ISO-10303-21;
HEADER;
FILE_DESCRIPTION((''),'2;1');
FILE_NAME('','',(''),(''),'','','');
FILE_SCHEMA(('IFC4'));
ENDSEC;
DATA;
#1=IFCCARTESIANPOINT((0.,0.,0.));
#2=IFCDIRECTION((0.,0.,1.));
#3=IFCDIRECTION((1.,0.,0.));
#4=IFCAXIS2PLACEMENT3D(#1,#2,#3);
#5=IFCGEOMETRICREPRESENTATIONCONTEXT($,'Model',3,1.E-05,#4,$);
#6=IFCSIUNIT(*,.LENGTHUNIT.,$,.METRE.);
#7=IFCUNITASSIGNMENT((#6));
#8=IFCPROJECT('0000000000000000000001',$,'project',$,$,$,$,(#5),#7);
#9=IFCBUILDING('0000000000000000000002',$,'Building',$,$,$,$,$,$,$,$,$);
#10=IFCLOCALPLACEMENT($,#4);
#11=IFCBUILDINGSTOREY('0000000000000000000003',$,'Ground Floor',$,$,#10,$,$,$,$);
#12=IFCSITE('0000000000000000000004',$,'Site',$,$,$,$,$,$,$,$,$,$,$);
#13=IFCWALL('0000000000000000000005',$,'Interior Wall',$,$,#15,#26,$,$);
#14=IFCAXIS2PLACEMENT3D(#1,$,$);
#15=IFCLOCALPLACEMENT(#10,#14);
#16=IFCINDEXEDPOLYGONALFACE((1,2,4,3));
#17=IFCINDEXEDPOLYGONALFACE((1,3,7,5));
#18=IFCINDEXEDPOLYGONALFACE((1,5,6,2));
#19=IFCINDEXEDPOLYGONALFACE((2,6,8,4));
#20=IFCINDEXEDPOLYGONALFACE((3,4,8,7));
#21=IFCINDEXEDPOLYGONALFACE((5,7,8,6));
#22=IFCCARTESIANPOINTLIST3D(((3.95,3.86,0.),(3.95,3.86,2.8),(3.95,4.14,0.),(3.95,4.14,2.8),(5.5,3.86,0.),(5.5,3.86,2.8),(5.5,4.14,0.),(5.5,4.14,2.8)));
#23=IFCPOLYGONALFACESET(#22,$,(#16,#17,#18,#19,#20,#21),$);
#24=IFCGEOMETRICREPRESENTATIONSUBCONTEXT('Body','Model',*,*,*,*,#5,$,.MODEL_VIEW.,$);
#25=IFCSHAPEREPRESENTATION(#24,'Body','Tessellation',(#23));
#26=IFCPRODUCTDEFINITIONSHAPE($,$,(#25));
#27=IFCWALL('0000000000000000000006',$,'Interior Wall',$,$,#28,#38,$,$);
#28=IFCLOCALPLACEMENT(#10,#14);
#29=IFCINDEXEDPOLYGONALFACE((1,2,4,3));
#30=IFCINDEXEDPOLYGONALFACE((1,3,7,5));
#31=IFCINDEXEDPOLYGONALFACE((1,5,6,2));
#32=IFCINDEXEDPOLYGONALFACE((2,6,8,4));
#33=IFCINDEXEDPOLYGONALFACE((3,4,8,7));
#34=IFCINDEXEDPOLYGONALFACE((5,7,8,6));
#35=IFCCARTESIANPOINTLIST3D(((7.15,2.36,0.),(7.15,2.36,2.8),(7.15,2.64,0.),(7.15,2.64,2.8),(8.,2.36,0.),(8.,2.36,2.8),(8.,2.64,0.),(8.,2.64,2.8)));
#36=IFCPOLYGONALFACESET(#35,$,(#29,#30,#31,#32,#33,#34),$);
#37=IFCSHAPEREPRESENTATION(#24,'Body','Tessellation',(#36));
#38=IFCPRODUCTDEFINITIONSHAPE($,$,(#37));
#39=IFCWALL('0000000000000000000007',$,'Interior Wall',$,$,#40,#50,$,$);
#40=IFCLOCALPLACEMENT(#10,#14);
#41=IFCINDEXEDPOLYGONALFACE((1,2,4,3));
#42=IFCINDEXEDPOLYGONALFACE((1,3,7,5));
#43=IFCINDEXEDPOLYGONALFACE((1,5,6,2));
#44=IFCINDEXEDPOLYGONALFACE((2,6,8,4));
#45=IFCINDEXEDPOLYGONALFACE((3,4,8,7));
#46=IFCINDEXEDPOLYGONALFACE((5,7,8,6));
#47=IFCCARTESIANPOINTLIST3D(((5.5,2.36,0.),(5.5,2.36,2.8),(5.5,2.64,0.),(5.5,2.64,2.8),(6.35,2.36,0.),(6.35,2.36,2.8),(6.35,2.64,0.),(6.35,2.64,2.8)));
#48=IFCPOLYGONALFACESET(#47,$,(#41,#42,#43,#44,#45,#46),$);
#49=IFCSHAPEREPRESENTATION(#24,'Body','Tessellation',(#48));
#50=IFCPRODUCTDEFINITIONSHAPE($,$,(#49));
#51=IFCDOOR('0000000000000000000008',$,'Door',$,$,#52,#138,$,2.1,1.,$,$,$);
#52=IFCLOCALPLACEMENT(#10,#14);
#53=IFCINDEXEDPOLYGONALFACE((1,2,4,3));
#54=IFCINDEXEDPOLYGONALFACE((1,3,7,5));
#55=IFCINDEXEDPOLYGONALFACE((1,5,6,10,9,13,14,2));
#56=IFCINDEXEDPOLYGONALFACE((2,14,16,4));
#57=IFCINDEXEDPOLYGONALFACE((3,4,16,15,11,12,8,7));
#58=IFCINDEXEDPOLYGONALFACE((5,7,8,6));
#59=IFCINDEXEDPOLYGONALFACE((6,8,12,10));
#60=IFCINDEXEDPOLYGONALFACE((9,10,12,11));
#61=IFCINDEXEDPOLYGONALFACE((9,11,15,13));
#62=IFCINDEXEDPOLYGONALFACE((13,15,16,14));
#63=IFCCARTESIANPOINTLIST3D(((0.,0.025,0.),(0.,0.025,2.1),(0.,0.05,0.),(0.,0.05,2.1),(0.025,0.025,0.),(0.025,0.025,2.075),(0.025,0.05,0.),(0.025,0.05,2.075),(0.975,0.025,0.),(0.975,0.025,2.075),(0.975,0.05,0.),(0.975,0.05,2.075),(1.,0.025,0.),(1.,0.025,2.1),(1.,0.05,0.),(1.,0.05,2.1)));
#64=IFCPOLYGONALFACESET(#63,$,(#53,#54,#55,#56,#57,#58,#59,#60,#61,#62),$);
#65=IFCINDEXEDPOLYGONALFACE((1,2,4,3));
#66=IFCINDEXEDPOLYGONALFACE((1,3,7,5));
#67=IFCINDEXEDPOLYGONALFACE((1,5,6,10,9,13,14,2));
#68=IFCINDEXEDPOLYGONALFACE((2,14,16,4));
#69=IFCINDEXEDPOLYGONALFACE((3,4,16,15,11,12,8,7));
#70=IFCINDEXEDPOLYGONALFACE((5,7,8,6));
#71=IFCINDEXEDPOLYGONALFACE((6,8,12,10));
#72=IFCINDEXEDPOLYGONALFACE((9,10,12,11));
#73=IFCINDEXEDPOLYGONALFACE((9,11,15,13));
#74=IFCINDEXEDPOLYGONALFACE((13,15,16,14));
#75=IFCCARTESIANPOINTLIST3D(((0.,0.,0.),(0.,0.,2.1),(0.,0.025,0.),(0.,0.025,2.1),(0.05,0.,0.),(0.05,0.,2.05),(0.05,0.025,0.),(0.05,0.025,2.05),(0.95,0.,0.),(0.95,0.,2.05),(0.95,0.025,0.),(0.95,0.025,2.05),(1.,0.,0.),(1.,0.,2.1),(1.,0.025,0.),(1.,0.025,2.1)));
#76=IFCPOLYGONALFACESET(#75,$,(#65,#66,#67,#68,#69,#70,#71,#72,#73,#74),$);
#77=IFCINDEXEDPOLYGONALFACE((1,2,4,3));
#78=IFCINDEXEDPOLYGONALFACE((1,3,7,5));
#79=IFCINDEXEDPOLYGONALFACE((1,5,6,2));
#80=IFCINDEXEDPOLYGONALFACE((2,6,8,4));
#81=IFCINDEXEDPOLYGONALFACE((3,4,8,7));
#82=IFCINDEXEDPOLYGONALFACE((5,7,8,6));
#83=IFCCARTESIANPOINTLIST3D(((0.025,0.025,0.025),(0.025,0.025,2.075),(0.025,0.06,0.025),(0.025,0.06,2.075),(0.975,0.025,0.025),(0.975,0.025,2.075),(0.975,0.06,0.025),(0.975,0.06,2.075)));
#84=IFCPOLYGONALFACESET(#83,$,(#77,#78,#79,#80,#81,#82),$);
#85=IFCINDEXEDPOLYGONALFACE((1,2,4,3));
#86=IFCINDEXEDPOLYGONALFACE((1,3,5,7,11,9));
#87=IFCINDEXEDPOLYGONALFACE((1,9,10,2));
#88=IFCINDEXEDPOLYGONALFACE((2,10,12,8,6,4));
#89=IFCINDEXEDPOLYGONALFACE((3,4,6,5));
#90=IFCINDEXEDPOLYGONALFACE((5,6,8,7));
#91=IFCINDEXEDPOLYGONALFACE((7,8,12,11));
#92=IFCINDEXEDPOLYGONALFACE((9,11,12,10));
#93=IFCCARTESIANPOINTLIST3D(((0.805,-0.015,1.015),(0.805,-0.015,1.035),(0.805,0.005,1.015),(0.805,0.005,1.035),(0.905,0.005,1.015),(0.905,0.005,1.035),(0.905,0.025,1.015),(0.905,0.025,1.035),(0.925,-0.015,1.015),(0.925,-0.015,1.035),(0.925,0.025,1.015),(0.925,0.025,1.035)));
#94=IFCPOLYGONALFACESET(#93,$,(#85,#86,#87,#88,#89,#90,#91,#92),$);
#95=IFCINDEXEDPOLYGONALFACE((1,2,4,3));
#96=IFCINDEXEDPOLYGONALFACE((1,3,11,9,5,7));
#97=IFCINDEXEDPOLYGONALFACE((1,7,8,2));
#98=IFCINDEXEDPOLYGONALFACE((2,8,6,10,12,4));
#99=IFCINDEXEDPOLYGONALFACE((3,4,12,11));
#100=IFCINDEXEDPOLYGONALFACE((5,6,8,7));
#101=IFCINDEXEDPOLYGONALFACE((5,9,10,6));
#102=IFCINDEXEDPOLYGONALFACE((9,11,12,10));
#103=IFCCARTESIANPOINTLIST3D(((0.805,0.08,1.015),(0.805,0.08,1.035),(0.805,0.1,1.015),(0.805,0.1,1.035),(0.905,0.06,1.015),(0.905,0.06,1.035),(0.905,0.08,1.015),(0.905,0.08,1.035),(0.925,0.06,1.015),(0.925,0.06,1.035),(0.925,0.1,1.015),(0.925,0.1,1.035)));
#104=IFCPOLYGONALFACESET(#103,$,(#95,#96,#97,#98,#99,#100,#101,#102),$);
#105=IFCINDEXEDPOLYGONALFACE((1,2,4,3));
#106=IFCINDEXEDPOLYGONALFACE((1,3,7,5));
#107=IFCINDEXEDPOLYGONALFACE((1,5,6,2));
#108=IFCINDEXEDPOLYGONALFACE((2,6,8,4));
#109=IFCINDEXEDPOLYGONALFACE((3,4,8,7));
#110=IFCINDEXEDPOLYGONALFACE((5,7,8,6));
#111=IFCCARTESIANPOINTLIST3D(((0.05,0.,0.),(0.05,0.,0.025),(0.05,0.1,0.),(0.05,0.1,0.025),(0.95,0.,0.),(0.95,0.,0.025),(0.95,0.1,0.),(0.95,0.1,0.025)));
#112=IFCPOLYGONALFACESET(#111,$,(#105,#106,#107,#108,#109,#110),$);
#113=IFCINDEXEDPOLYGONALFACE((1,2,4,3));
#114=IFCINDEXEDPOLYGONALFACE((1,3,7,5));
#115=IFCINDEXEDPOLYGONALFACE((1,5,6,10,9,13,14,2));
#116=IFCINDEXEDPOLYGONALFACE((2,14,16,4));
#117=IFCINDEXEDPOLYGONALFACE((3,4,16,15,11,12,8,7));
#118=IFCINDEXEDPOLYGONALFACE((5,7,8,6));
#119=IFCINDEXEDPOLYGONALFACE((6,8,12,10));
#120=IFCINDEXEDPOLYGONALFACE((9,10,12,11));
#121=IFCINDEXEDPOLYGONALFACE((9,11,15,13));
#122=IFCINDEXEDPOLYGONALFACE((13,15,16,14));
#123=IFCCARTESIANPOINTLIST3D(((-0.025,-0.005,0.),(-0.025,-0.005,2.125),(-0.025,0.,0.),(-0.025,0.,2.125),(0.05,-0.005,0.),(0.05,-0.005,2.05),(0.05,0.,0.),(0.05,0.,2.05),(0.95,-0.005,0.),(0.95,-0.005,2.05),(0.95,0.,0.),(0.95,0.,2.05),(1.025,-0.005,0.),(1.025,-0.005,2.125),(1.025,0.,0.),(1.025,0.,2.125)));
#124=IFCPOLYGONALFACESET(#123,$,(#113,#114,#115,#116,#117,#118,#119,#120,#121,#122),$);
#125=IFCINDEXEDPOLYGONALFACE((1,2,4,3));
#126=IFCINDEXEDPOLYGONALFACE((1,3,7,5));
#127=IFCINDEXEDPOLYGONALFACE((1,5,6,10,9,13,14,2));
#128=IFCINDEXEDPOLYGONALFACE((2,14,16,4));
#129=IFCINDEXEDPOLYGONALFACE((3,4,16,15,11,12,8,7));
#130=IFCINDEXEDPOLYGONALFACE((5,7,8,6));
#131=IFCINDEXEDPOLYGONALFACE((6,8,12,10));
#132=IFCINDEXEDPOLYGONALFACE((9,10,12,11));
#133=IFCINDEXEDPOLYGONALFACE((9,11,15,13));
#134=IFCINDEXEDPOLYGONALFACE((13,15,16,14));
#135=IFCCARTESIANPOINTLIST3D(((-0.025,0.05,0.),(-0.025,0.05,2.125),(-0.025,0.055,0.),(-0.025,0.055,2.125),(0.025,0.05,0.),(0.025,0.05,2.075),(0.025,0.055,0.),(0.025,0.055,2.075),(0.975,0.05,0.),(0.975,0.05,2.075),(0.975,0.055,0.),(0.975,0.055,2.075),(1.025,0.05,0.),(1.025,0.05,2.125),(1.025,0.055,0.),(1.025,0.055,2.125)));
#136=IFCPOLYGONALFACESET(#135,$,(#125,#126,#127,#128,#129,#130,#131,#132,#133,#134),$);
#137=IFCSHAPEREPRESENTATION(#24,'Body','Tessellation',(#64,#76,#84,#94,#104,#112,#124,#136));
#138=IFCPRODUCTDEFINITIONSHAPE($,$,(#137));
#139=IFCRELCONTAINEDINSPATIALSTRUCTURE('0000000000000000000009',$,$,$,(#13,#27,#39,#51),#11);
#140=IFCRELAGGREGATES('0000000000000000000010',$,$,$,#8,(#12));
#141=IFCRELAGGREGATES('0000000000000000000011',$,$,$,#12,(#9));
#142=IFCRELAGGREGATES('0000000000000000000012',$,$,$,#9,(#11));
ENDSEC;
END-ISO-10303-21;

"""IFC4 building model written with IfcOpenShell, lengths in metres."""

from ifc_helpers import new_model, si_unit, frame, origin_with_axes, place, context, subcontext, project, spatial, line, indexed_curve, outline, extrude, element, save


model = new_model("IFC4")

# Units and contexts
model_context = context("Model", 3, precision=1e-05, world=origin_with_axes())
body_context = subcontext(model_context, "Body", "Model", "MODEL_VIEW")
ifc_project = project(units=[si_unit("LENGTHUNIT", "METRE")], contexts=[model_context])

# Site, building, storey
site = spatial("IfcSite", under=ifc_project, Name="Site")
building = spatial("IfcBuilding", under=site, Name="Building")
storey_placement = place(None, origin_with_axes())
storey = spatial("IfcBuildingStorey", under=building, at=storey_placement, Name="Ground Floor")

# Walls
wall_1_placement = place(storey_placement, frame((5.5, 4.0, 0.0), z_axis=(0.0, 0.0, 1.0), x_axis=(-1.0, 0.0, 0.0)))
element("IfcWall", 1, at=wall_1_placement, inside=storey, Name="Interior Wall", context=body_context, shape_type="SweptSolid", body=[
    extrude(outline(indexed_curve([(0.0, 0.0), (0.0, 0.28), (1.55, 0.28), (1.55, 0.0), (0.0, 0.0)], self_intersect=False)), frame((0.0, -0.14, 0.0), z_axis=(0.0, 0.0, 1.0), x_axis=(1.0, 0.0, 0.0)), (0.0, 0.0, 1.0), 2.8),
])
for number, where, z_axis, x_axis, name in (
    (2, (8.0, 2.5, 0.0), (0.0, 0.0, 1.0), (-1.0, 0.0, 0.0), "Interior Wall"),
    (3, (6.35, 2.5, 0.0), (0.0, 0.0, 1.0), (-1.0, 0.0, 0.0), "Interior Wall"),
):
    element("IfcWall", number, at=place(storey_placement, frame(where, z_axis=z_axis, x_axis=x_axis)), inside=storey, Name=name, context=body_context, shape_type="SweptSolid", body=[
        extrude(outline(indexed_curve([(0.0, 0.0), (0.0, 0.28), (0.85, 0.28), (0.85, 0.0), (0.0, 0.0)], self_intersect=False)), frame((0.0, -0.14, 0.0), z_axis=(0.0, 0.0, 1.0), x_axis=(1.0, 0.0, 0.0)), (0.0, 0.0, 1.0), 2.8),
    ])

# Door
door_1_placement = place(storey_placement, origin_with_axes())
element("IfcDoor", 4, at=door_1_placement, inside=storey, Name="Door", OverallHeight=2.1, OverallWidth=1.0, context=body_context, shape_type="SweptSolid", body=[
    extrude(outline(indexed_curve([(0.0, 0.0), (0.0, 2.1), (1.0, 2.1), (1.0, 0.0), (0.975, 0.0), (0.975, 2.075), (0.025, 2.075), (0.025, 0.0)], segments=[line(1, 2, 3, 4, 5, 6, 7, 8, 1)])), frame((0.0, 0.025, 0.0), z_axis=(0.0, -1.0, 0.0), x_axis=(1.0, 0.0, 0.0)), (0.0, 0.0, -1.0), 0.025),
    extrude(outline(indexed_curve([(0.0, 0.0), (0.0, 2.1), (1.0, 2.1), (1.0, 0.0), (0.95, 0.0), (0.95, 2.05), (0.05, 2.05), (0.05, 0.0)], segments=[line(1, 2, 3, 4, 5, 6, 7, 8, 1)])), frame((0.0, 0.0, 0.0), z_axis=(0.0, -1.0, 0.0), x_axis=(1.0, 0.0, 0.0)), (0.0, 0.0, -1.0), 0.025),
    extrude(outline(indexed_curve([(0.0, 0.0), (0.95, 0.0), (0.95, 0.035), (0.0, 0.035)], segments=[line(1, 2, 3, 4, 1)])), frame((0.025, 0.025, 0.025), z_axis=(0.0, 0.0, 1.0), x_axis=(1.0, 0.0, 0.0)), (0.0, 0.0, 1.0), 2.05),
    extrude(outline(indexed_curve([(0.0, 0.0), (0.0, -0.04), (-0.12, -0.04), (-0.12, -0.02), (-0.02, -0.02), (-0.02, 0.0)], segments=[line(1, 2, 3, 4, 5, 6, 1)])), frame((0.925, 0.025, 1.015), z_axis=(0.0, 0.0, 1.0), x_axis=(1.0, 0.0, 0.0)), (0.0, 0.0, 1.0), 0.02),
    extrude(outline(indexed_curve([(0.0, 0.0), (0.0, 0.04), (-0.12, 0.04), (-0.12, 0.02), (-0.02, 0.02), (-0.02, 0.0)], segments=[line(1, 2, 3, 4, 5, 6, 1)])), frame((0.925, 0.06, 1.015), z_axis=(0.0, 0.0, 1.0), x_axis=(1.0, 0.0, 0.0)), (0.0, 0.0, 1.0), 0.02),
    extrude(outline(indexed_curve([(0.0, 0.0), (0.9, 0.0), (0.9, 0.1), (0.0, 0.1)], segments=[line(1, 2, 3, 4, 1)])), frame((0.05, 0.0, 0.0), z_axis=(0.0, 0.0, 1.0), x_axis=(1.0, 0.0, 0.0)), (0.0, 0.0, 1.0), 0.025),
    extrude(outline(indexed_curve([(0.0, 0.0), (0.0, 2.125), (1.05, 2.125), (1.05, 0.0), (0.975, 0.0), (0.975, 2.05), (0.075, 2.05), (0.075, 0.0)], segments=[line(1, 2, 3, 4, 5, 6, 7, 8, 1)])), frame((-0.025, -0.005, 0.0), z_axis=(0.0, -1.0, 0.0), x_axis=(1.0, 0.0, 0.0)), (0.0, 0.0, -1.0), 0.005),
    extrude(outline(indexed_curve([(0.0, 0.0), (0.0, 2.125), (1.05, 2.125), (1.05, 0.0), (1.0, 0.0), (1.0, 2.075), (0.05, 2.075), (0.05, 0.0)], segments=[line(1, 2, 3, 4, 5, 6, 7, 8, 1)])), frame((-0.025, 0.05, 0.0), z_axis=(0.0, -1.0, 0.0), x_axis=(1.0, 0.0, 0.0)), (0.0, 0.0, -1.0), 0.005),
])

save(model, "model.ifc")
